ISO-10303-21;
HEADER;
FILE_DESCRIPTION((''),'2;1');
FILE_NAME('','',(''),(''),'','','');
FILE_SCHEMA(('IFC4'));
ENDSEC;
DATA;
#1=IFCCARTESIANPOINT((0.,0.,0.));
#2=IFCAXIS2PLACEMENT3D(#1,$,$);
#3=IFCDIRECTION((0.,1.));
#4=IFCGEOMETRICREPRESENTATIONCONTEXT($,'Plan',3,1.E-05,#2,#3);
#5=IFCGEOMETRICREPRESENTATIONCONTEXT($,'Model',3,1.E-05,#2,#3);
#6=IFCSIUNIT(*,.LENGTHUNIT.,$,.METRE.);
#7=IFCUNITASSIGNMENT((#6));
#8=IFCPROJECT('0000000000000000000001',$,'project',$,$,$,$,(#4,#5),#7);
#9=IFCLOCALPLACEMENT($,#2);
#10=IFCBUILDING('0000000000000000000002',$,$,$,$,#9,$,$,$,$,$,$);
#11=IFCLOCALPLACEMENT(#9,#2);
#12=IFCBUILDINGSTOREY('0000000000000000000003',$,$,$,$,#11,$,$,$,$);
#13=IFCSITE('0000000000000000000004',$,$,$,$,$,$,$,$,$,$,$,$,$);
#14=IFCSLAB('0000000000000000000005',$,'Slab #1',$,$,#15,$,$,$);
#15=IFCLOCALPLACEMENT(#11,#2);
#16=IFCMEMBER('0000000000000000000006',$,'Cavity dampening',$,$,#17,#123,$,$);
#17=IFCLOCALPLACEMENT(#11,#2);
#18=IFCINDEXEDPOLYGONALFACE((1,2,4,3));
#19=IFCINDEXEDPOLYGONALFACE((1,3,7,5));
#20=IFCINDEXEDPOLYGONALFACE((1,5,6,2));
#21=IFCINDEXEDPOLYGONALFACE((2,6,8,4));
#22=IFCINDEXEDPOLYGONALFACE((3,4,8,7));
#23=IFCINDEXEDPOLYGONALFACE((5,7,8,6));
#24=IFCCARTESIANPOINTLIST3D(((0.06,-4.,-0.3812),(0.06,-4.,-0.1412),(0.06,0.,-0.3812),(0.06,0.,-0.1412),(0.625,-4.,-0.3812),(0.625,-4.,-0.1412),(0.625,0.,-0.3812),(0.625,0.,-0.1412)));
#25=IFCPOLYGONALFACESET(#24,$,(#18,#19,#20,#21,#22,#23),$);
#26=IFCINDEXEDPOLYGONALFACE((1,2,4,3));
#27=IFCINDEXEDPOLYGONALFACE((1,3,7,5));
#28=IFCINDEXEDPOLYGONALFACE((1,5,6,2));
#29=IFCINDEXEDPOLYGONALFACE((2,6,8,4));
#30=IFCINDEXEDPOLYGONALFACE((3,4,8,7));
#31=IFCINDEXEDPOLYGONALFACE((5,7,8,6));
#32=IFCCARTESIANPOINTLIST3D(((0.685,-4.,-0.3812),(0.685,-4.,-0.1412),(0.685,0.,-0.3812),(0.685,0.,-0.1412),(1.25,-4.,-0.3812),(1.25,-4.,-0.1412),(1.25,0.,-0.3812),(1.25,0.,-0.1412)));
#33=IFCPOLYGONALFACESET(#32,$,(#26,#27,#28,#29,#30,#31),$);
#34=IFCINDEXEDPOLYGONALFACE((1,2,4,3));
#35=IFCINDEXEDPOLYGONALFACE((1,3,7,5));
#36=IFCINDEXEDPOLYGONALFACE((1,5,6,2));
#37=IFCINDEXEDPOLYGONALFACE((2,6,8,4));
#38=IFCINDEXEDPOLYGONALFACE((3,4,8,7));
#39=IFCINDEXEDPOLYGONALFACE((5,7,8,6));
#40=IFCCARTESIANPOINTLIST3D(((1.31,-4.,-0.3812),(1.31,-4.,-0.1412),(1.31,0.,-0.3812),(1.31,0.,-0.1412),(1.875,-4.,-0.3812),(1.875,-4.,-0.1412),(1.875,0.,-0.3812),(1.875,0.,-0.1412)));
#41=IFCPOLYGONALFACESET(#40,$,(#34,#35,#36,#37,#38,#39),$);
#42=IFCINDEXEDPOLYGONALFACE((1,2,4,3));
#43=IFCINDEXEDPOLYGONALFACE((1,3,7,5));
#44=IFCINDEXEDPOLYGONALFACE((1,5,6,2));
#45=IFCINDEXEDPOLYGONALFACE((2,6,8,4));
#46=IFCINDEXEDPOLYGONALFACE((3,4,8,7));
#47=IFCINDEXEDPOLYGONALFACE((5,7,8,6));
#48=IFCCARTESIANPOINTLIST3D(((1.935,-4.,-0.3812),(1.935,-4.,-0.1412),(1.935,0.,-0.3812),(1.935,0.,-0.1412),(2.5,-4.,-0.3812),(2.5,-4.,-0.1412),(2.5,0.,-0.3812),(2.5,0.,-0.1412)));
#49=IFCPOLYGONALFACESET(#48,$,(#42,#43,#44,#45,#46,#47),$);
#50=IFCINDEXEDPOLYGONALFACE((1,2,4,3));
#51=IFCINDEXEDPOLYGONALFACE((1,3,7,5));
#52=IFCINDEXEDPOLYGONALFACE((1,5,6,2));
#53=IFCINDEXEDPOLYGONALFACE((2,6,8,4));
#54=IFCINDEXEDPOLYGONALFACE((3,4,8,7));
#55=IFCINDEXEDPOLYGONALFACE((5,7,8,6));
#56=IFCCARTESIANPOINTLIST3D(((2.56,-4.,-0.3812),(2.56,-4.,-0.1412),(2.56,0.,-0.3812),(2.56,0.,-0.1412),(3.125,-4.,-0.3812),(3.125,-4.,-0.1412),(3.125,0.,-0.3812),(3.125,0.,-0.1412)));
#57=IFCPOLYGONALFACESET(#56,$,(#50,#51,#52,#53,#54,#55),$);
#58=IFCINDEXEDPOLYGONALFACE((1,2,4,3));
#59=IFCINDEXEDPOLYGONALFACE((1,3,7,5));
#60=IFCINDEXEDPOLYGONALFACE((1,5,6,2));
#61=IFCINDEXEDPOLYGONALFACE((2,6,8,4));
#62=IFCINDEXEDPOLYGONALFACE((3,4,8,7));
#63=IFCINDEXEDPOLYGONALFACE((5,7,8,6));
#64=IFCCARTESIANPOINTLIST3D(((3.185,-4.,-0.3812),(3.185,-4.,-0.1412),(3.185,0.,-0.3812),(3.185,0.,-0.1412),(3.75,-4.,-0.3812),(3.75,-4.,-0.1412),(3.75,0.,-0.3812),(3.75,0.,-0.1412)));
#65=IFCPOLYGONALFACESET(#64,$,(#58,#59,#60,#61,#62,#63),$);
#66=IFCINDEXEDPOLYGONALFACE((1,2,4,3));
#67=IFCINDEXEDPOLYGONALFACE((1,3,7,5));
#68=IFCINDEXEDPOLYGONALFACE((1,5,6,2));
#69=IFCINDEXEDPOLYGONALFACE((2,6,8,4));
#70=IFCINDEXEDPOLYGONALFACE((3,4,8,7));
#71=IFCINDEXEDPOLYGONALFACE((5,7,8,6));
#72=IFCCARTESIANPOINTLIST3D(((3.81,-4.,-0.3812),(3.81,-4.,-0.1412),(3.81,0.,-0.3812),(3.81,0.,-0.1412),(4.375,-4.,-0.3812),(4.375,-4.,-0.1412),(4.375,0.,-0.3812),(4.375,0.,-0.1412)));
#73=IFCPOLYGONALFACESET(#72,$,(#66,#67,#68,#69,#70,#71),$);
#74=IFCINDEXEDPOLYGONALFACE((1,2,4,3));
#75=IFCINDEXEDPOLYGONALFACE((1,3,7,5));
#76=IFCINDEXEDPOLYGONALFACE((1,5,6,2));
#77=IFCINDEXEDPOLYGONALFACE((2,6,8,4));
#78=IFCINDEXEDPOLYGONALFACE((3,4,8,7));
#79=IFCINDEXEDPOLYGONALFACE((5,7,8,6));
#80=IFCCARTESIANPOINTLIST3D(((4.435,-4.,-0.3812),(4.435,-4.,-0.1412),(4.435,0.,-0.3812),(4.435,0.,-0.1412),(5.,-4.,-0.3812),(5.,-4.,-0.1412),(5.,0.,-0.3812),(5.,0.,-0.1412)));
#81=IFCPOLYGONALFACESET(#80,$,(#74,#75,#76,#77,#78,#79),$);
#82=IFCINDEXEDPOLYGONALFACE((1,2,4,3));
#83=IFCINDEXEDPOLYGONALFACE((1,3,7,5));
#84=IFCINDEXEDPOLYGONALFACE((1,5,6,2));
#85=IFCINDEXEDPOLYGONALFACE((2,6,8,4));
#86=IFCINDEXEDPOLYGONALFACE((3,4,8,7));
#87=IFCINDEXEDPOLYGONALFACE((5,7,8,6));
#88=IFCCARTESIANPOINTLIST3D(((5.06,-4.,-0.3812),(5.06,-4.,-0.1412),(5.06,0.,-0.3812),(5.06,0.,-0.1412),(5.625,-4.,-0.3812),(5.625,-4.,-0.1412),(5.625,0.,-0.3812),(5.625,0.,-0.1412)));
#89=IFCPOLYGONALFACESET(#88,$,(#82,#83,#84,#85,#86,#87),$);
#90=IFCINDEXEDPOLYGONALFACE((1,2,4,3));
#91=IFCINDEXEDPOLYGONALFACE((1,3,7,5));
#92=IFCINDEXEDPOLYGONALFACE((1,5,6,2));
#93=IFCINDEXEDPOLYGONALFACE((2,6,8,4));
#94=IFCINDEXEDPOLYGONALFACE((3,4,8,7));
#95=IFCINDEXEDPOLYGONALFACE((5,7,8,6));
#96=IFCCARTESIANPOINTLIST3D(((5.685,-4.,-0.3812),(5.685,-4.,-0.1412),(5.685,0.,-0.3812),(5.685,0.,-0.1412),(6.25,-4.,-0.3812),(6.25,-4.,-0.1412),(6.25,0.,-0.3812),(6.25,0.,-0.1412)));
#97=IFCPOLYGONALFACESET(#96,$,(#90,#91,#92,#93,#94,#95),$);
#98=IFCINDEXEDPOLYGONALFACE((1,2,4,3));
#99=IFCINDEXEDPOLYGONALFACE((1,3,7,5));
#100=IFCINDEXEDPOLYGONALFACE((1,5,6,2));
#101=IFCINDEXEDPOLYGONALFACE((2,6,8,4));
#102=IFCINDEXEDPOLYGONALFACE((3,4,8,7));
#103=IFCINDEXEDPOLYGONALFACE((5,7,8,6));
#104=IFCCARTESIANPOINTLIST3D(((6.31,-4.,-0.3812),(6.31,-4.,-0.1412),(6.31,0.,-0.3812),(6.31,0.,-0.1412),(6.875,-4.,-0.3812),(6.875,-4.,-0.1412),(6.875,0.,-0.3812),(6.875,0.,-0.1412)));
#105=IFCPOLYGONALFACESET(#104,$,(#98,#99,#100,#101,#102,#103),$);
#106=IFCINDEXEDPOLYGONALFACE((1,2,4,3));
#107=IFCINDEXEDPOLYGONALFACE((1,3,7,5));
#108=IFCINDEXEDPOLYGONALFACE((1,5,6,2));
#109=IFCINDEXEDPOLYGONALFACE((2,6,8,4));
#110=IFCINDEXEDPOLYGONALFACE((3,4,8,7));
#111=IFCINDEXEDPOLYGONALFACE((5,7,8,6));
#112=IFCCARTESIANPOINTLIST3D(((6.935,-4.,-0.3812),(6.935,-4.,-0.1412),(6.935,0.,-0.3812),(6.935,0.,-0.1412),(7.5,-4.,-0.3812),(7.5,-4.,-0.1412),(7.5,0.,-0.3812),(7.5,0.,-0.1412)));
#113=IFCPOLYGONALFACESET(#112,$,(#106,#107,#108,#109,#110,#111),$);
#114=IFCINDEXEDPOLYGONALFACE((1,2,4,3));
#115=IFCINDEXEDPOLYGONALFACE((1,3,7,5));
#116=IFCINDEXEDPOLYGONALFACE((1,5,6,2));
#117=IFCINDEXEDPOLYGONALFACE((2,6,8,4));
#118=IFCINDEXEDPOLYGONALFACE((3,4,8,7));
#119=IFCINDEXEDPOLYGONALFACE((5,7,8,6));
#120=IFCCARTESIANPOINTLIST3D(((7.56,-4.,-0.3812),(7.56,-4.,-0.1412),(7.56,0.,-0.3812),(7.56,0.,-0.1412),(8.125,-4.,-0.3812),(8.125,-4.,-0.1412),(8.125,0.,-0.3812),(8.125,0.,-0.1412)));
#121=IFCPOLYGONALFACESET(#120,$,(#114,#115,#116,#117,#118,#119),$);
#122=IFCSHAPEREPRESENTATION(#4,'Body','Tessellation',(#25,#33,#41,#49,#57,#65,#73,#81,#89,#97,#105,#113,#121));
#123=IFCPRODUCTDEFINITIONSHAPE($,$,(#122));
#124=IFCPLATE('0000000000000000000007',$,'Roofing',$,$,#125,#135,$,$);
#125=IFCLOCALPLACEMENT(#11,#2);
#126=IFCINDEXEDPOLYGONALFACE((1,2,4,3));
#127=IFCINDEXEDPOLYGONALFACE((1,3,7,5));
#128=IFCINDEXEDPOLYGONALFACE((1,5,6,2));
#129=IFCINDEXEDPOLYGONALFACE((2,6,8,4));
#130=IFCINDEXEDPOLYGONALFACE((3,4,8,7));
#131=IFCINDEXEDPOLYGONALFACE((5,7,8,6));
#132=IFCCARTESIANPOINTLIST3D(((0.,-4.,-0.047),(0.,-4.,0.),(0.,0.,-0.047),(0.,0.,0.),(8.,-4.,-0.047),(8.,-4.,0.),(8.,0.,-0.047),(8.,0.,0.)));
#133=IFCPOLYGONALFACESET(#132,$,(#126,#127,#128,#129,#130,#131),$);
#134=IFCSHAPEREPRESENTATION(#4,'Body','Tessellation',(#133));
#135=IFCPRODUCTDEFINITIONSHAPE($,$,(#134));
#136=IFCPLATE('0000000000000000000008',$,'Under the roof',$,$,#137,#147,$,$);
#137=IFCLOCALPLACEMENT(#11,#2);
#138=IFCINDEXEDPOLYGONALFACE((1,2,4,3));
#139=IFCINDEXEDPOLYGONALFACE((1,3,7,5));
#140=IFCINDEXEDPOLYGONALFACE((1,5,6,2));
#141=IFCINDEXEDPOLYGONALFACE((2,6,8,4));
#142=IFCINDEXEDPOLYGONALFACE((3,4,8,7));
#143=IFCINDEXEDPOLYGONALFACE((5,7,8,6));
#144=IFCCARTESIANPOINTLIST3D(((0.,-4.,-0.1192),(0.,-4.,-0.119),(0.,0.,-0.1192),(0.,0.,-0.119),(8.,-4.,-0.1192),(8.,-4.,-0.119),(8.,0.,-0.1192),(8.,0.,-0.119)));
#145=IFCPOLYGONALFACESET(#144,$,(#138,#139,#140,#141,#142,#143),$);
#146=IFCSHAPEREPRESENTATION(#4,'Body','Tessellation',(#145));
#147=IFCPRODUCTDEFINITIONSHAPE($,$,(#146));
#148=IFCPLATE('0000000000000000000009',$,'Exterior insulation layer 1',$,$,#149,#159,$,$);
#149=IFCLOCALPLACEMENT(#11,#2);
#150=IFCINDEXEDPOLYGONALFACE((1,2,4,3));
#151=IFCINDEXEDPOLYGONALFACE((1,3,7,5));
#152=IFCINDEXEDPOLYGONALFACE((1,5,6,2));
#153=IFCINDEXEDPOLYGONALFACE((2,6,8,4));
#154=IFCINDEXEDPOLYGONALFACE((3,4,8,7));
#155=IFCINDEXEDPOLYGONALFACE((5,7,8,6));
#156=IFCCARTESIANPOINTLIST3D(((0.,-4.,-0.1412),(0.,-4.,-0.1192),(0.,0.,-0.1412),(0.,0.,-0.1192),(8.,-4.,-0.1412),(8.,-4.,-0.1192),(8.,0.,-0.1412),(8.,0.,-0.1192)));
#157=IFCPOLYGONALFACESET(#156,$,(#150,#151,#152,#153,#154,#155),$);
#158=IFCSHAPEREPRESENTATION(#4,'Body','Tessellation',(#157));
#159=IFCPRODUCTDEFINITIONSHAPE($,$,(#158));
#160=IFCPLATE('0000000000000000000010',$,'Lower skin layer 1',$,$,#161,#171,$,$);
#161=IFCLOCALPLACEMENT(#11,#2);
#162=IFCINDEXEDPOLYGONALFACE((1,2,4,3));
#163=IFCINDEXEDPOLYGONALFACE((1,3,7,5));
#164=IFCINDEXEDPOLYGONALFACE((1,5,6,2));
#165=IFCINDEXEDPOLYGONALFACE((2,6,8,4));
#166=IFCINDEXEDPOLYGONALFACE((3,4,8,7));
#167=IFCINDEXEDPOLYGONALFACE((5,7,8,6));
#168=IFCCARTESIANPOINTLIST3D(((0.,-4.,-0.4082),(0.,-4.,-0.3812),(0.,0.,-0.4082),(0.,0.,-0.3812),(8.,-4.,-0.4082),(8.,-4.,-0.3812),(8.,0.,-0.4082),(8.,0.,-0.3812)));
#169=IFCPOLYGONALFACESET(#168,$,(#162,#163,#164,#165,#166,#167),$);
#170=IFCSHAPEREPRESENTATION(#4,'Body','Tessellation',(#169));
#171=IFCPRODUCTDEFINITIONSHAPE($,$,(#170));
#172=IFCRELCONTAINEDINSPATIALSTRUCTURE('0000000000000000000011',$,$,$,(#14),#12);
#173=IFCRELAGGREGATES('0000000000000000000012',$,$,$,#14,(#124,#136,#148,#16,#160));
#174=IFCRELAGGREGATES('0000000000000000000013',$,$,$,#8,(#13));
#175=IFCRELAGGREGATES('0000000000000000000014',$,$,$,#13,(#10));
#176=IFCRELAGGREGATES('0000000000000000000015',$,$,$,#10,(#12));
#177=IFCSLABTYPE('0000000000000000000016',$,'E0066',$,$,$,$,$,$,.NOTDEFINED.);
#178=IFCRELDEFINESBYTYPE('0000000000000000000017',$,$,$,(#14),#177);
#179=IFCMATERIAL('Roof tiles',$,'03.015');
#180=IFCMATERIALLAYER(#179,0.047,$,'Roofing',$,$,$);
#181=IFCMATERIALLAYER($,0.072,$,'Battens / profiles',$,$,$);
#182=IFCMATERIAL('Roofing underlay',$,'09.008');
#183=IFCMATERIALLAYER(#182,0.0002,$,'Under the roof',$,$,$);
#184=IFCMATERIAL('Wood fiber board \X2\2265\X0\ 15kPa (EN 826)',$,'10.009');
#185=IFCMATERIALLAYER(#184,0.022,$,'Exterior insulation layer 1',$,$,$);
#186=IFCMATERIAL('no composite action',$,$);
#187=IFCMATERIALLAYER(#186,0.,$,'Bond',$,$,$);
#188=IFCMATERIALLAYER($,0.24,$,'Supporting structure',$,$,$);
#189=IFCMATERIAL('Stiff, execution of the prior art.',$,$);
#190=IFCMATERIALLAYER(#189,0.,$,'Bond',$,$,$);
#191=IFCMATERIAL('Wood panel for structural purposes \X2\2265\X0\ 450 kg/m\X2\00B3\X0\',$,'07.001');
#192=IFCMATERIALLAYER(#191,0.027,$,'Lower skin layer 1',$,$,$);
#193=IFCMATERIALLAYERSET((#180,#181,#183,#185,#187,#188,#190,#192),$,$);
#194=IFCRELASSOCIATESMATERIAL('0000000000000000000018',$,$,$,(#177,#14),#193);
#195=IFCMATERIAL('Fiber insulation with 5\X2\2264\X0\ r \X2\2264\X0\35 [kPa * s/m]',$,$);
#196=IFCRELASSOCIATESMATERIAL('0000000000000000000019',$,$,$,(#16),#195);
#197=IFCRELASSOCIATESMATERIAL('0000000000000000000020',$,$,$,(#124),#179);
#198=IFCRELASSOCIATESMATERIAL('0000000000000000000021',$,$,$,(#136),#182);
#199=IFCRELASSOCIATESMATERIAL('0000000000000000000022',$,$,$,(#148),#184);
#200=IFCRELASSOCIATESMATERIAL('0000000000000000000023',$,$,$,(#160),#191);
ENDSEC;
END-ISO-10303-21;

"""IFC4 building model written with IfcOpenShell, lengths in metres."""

from ifc_helpers import new_model, si_unit, direction, frame, frame_2d, origin, origin_with_axes, place, context, project, spatial, rectangle, extrude, material, layer, layer_set, type_object, element, aggregate, save


model = new_model("IFC4")

# Units and contexts
plan_context = context("Plan", 3, precision=1e-05, world=origin(), true_north=direction((0.0, 1.0)))
model_context = context("Model", 3, precision=1e-05, world=origin(), true_north=direction((0.0, 1.0)))
ifc_project = project(units=[si_unit("LENGTHUNIT", "METRE")], contexts=[plan_context, model_context])

# Site, building, storey
site = spatial("IfcSite", under=ifc_project)
building_placement = place(None, origin())
building = spatial("IfcBuilding", under=site, at=building_placement)
storey_placement = place(building_placement, origin())
storey = spatial("IfcBuildingStorey", under=building, at=storey_placement)

# Slab, member, plates
ifc_material_1 = material(Name="Roof tiles", Category="03.015")
ifc_layer_1 = layer(ifc_material_1, 0.047, Name="Roofing")
ifc_layer_2 = layer(None, 0.072, Name="Battens / profiles")
ifc_material_2 = material(Name="Roofing underlay", Category="09.008")
ifc_layer_3 = layer(ifc_material_2, 0.0002, Name="Under the roof")
ifc_material_3 = material(Name="Wood fiber board ≥ 15kPa (EN 826)", Category="10.009")
ifc_layer_4 = layer(ifc_material_3, 0.022, Name="Exterior insulation layer 1")
ifc_material_4 = material(Name="no composite action")
ifc_layer_5 = layer(ifc_material_4, 0.0, Name="Bond")
ifc_layer_6 = layer(None, 0.24, Name="Supporting structure")
ifc_material_5 = material(Name="Stiff, execution of the prior art.")
ifc_layer_7 = layer(ifc_material_5, 0.0, Name="Bond")
ifc_material_6 = material(Name="Wood panel for structural purposes ≥ 450 kg/m³", Category="07.001")
ifc_layer_8 = layer(ifc_material_6, 0.027, Name="Lower skin layer 1")
ifc_layer_set = layer_set([ifc_layer_1, ifc_layer_2, ifc_layer_3, ifc_layer_4, ifc_layer_5, ifc_layer_6, ifc_layer_7, ifc_layer_8])
slab_type = type_object("IfcSlabType", Name="E0066", PredefinedType="NOTDEFINED", material=ifc_layer_set)
slab_placement = place(None, frame((0.0, 0.0, 0.0), z_axis=(0.0, 0.0, -1.0), x_axis=(1.0, 0.0, 0.0)))
slab = element("IfcSlab", 1, at=slab_placement, inside=storey, type_object=slab_type, material=ifc_layer_set, Name="Slab #1")
ifc_material_7 = material(Name="Fiber insulation with 5≤ r ≤35 [kPa * s/m]")
member_1_placement = place(slab_placement, origin())
member_1 = element("IfcMember", 2, at=member_1_placement, material=ifc_material_7, Name="Cavity dampening", context=plan_context, shape_type="SweptSolid", body=[
    extrude(rectangle(XDim=0.565, YDim=0.24, at=frame_2d((0.2825, 0.12), x_axis=(1.0, 0.0))), frame((0.06, 4.0, 0.1412), z_axis=(0.0, -1.0, 0.0), x_axis=(1.0, 0.0, 0.0)), (0.0, 0.0, 1.0), 4.0),
    extrude(rectangle(XDim=0.565, YDim=0.24, at=frame_2d((0.2825, 0.12), x_axis=(1.0, 0.0))), frame((0.685, 4.0, 0.1412), z_axis=(0.0, -1.0, 0.0), x_axis=(1.0, 0.0, 0.0)), (0.0, 0.0, 1.0), 4.0),
    extrude(rectangle(XDim=0.565, YDim=0.24, at=frame_2d((0.2825, 0.12), x_axis=(1.0, 0.0))), frame((1.31, 4.0, 0.1412), z_axis=(0.0, -1.0, 0.0), x_axis=(1.0, 0.0, 0.0)), (0.0, 0.0, 1.0), 4.0),
    extrude(rectangle(XDim=0.565, YDim=0.24, at=frame_2d((0.2825, 0.12), x_axis=(1.0, 0.0))), frame((1.935, 4.0, 0.1412), z_axis=(0.0, -1.0, 0.0), x_axis=(1.0, 0.0, 0.0)), (0.0, 0.0, 1.0), 4.0),
    extrude(rectangle(XDim=0.565, YDim=0.24, at=frame_2d((0.2825, 0.12), x_axis=(1.0, 0.0))), frame((2.56, 4.0, 0.1412), z_axis=(0.0, -1.0, 0.0), x_axis=(1.0, 0.0, 0.0)), (0.0, 0.0, 1.0), 4.0),
    extrude(rectangle(XDim=0.565, YDim=0.24, at=frame_2d((0.2825, 0.12), x_axis=(1.0, 0.0))), frame((3.185, 4.0, 0.1412), z_axis=(0.0, -1.0, 0.0), x_axis=(1.0, 0.0, 0.0)), (0.0, 0.0, 1.0), 4.0),
    extrude(rectangle(XDim=0.565, YDim=0.24, at=frame_2d((0.2825, 0.12), x_axis=(1.0, 0.0))), frame((3.81, 4.0, 0.1412), z_axis=(0.0, -1.0, 0.0), x_axis=(1.0, 0.0, 0.0)), (0.0, 0.0, 1.0), 4.0),
    extrude(rectangle(XDim=0.565, YDim=0.24, at=frame_2d((0.2825, 0.12), x_axis=(1.0, 0.0))), frame((4.435, 4.0, 0.1412), z_axis=(0.0, -1.0, 0.0), x_axis=(1.0, 0.0, 0.0)), (0.0, 0.0, 1.0), 4.0),
    extrude(rectangle(XDim=0.565, YDim=0.24, at=frame_2d((0.2825, 0.12), x_axis=(1.0, 0.0))), frame((5.06, 4.0, 0.1412), z_axis=(0.0, -1.0, 0.0), x_axis=(1.0, 0.0, 0.0)), (0.0, 0.0, 1.0), 4.0),
    extrude(rectangle(XDim=0.565, YDim=0.24, at=frame_2d((0.2825, 0.12), x_axis=(1.0, 0.0))), frame((5.685, 4.0, 0.1412), z_axis=(0.0, -1.0, 0.0), x_axis=(1.0, 0.0, 0.0)), (0.0, 0.0, 1.0), 4.0),
    extrude(rectangle(XDim=0.565, YDim=0.24, at=frame_2d((0.2825, 0.12), x_axis=(1.0, 0.0))), frame((6.31, 4.0, 0.1412), z_axis=(0.0, -1.0, 0.0), x_axis=(1.0, 0.0, 0.0)), (0.0, 0.0, 1.0), 4.0),
    extrude(rectangle(XDim=0.565, YDim=0.24, at=frame_2d((0.2825, 0.12), x_axis=(1.0, 0.0))), frame((6.935, 4.0, 0.1412), z_axis=(0.0, -1.0, 0.0), x_axis=(1.0, 0.0, 0.0)), (0.0, 0.0, 1.0), 4.0),
    extrude(rectangle(XDim=0.565, YDim=0.24, at=frame_2d((0.2825, 0.12), x_axis=(1.0, 0.0))), frame((7.56, 4.0, 0.1412), z_axis=(0.0, -1.0, 0.0), x_axis=(1.0, 0.0, 0.0)), (0.0, 0.0, 1.0), 4.0),
])
plate_1_placement = place(slab_placement, origin())
plate_1 = element("IfcPlate", 3, at=plate_1_placement, material=ifc_material_1, Name="Roofing", context=plan_context, shape_type="SweptSolid", body=[
    extrude(rectangle(XDim=8.0, YDim=4.0, at=frame_2d((4.0, 2.0), x_axis=(1.0, 0.0))), origin_with_axes(), (0.0, 0.0, 1.0), 0.047),
])
plate_2_placement = place(slab_placement, origin())
plate_2 = element("IfcPlate", 4, at=plate_2_placement, material=ifc_material_2, Name="Under the roof", context=plan_context, shape_type="SweptSolid", body=[
    extrude(rectangle(XDim=8.0, YDim=4.0, at=frame_2d((4.0, 2.0), x_axis=(1.0, 0.0))), frame((0.0, 0.0, 0.119), z_axis=(0.0, 0.0, 1.0), x_axis=(1.0, 0.0, 0.0)), (0.0, 0.0, 1.0), 0.0002),
])
plate_3_placement = place(slab_placement, origin())
plate_3 = element("IfcPlate", 5, at=plate_3_placement, material=ifc_material_3, Name="Exterior insulation layer 1", context=plan_context, shape_type="SweptSolid", body=[
    extrude(rectangle(XDim=8.0, YDim=4.0, at=frame_2d((4.0, 2.0), x_axis=(1.0, 0.0))), frame((0.0, 0.0, 0.1192), z_axis=(0.0, 0.0, 1.0), x_axis=(1.0, 0.0, 0.0)), (0.0, 0.0, 1.0), 0.022),
])
plate_4_placement = place(slab_placement, origin())
plate_4 = element("IfcPlate", 6, at=plate_4_placement, material=ifc_material_6, Name="Lower skin layer 1", context=plan_context, shape_type="SweptSolid", body=[
    extrude(rectangle(XDim=8.0, YDim=4.0, at=frame_2d((4.0, 2.0), x_axis=(1.0, 0.0))), frame((0.0, 0.0, 0.3812), z_axis=(0.0, 0.0, 1.0), x_axis=(1.0, 0.0, 0.0)), (0.0, 0.0, 1.0), 0.027),
])
aggregate(slab, [plate_1, plate_2, plate_3, member_1, plate_4])

save(model, "model.ifc")
